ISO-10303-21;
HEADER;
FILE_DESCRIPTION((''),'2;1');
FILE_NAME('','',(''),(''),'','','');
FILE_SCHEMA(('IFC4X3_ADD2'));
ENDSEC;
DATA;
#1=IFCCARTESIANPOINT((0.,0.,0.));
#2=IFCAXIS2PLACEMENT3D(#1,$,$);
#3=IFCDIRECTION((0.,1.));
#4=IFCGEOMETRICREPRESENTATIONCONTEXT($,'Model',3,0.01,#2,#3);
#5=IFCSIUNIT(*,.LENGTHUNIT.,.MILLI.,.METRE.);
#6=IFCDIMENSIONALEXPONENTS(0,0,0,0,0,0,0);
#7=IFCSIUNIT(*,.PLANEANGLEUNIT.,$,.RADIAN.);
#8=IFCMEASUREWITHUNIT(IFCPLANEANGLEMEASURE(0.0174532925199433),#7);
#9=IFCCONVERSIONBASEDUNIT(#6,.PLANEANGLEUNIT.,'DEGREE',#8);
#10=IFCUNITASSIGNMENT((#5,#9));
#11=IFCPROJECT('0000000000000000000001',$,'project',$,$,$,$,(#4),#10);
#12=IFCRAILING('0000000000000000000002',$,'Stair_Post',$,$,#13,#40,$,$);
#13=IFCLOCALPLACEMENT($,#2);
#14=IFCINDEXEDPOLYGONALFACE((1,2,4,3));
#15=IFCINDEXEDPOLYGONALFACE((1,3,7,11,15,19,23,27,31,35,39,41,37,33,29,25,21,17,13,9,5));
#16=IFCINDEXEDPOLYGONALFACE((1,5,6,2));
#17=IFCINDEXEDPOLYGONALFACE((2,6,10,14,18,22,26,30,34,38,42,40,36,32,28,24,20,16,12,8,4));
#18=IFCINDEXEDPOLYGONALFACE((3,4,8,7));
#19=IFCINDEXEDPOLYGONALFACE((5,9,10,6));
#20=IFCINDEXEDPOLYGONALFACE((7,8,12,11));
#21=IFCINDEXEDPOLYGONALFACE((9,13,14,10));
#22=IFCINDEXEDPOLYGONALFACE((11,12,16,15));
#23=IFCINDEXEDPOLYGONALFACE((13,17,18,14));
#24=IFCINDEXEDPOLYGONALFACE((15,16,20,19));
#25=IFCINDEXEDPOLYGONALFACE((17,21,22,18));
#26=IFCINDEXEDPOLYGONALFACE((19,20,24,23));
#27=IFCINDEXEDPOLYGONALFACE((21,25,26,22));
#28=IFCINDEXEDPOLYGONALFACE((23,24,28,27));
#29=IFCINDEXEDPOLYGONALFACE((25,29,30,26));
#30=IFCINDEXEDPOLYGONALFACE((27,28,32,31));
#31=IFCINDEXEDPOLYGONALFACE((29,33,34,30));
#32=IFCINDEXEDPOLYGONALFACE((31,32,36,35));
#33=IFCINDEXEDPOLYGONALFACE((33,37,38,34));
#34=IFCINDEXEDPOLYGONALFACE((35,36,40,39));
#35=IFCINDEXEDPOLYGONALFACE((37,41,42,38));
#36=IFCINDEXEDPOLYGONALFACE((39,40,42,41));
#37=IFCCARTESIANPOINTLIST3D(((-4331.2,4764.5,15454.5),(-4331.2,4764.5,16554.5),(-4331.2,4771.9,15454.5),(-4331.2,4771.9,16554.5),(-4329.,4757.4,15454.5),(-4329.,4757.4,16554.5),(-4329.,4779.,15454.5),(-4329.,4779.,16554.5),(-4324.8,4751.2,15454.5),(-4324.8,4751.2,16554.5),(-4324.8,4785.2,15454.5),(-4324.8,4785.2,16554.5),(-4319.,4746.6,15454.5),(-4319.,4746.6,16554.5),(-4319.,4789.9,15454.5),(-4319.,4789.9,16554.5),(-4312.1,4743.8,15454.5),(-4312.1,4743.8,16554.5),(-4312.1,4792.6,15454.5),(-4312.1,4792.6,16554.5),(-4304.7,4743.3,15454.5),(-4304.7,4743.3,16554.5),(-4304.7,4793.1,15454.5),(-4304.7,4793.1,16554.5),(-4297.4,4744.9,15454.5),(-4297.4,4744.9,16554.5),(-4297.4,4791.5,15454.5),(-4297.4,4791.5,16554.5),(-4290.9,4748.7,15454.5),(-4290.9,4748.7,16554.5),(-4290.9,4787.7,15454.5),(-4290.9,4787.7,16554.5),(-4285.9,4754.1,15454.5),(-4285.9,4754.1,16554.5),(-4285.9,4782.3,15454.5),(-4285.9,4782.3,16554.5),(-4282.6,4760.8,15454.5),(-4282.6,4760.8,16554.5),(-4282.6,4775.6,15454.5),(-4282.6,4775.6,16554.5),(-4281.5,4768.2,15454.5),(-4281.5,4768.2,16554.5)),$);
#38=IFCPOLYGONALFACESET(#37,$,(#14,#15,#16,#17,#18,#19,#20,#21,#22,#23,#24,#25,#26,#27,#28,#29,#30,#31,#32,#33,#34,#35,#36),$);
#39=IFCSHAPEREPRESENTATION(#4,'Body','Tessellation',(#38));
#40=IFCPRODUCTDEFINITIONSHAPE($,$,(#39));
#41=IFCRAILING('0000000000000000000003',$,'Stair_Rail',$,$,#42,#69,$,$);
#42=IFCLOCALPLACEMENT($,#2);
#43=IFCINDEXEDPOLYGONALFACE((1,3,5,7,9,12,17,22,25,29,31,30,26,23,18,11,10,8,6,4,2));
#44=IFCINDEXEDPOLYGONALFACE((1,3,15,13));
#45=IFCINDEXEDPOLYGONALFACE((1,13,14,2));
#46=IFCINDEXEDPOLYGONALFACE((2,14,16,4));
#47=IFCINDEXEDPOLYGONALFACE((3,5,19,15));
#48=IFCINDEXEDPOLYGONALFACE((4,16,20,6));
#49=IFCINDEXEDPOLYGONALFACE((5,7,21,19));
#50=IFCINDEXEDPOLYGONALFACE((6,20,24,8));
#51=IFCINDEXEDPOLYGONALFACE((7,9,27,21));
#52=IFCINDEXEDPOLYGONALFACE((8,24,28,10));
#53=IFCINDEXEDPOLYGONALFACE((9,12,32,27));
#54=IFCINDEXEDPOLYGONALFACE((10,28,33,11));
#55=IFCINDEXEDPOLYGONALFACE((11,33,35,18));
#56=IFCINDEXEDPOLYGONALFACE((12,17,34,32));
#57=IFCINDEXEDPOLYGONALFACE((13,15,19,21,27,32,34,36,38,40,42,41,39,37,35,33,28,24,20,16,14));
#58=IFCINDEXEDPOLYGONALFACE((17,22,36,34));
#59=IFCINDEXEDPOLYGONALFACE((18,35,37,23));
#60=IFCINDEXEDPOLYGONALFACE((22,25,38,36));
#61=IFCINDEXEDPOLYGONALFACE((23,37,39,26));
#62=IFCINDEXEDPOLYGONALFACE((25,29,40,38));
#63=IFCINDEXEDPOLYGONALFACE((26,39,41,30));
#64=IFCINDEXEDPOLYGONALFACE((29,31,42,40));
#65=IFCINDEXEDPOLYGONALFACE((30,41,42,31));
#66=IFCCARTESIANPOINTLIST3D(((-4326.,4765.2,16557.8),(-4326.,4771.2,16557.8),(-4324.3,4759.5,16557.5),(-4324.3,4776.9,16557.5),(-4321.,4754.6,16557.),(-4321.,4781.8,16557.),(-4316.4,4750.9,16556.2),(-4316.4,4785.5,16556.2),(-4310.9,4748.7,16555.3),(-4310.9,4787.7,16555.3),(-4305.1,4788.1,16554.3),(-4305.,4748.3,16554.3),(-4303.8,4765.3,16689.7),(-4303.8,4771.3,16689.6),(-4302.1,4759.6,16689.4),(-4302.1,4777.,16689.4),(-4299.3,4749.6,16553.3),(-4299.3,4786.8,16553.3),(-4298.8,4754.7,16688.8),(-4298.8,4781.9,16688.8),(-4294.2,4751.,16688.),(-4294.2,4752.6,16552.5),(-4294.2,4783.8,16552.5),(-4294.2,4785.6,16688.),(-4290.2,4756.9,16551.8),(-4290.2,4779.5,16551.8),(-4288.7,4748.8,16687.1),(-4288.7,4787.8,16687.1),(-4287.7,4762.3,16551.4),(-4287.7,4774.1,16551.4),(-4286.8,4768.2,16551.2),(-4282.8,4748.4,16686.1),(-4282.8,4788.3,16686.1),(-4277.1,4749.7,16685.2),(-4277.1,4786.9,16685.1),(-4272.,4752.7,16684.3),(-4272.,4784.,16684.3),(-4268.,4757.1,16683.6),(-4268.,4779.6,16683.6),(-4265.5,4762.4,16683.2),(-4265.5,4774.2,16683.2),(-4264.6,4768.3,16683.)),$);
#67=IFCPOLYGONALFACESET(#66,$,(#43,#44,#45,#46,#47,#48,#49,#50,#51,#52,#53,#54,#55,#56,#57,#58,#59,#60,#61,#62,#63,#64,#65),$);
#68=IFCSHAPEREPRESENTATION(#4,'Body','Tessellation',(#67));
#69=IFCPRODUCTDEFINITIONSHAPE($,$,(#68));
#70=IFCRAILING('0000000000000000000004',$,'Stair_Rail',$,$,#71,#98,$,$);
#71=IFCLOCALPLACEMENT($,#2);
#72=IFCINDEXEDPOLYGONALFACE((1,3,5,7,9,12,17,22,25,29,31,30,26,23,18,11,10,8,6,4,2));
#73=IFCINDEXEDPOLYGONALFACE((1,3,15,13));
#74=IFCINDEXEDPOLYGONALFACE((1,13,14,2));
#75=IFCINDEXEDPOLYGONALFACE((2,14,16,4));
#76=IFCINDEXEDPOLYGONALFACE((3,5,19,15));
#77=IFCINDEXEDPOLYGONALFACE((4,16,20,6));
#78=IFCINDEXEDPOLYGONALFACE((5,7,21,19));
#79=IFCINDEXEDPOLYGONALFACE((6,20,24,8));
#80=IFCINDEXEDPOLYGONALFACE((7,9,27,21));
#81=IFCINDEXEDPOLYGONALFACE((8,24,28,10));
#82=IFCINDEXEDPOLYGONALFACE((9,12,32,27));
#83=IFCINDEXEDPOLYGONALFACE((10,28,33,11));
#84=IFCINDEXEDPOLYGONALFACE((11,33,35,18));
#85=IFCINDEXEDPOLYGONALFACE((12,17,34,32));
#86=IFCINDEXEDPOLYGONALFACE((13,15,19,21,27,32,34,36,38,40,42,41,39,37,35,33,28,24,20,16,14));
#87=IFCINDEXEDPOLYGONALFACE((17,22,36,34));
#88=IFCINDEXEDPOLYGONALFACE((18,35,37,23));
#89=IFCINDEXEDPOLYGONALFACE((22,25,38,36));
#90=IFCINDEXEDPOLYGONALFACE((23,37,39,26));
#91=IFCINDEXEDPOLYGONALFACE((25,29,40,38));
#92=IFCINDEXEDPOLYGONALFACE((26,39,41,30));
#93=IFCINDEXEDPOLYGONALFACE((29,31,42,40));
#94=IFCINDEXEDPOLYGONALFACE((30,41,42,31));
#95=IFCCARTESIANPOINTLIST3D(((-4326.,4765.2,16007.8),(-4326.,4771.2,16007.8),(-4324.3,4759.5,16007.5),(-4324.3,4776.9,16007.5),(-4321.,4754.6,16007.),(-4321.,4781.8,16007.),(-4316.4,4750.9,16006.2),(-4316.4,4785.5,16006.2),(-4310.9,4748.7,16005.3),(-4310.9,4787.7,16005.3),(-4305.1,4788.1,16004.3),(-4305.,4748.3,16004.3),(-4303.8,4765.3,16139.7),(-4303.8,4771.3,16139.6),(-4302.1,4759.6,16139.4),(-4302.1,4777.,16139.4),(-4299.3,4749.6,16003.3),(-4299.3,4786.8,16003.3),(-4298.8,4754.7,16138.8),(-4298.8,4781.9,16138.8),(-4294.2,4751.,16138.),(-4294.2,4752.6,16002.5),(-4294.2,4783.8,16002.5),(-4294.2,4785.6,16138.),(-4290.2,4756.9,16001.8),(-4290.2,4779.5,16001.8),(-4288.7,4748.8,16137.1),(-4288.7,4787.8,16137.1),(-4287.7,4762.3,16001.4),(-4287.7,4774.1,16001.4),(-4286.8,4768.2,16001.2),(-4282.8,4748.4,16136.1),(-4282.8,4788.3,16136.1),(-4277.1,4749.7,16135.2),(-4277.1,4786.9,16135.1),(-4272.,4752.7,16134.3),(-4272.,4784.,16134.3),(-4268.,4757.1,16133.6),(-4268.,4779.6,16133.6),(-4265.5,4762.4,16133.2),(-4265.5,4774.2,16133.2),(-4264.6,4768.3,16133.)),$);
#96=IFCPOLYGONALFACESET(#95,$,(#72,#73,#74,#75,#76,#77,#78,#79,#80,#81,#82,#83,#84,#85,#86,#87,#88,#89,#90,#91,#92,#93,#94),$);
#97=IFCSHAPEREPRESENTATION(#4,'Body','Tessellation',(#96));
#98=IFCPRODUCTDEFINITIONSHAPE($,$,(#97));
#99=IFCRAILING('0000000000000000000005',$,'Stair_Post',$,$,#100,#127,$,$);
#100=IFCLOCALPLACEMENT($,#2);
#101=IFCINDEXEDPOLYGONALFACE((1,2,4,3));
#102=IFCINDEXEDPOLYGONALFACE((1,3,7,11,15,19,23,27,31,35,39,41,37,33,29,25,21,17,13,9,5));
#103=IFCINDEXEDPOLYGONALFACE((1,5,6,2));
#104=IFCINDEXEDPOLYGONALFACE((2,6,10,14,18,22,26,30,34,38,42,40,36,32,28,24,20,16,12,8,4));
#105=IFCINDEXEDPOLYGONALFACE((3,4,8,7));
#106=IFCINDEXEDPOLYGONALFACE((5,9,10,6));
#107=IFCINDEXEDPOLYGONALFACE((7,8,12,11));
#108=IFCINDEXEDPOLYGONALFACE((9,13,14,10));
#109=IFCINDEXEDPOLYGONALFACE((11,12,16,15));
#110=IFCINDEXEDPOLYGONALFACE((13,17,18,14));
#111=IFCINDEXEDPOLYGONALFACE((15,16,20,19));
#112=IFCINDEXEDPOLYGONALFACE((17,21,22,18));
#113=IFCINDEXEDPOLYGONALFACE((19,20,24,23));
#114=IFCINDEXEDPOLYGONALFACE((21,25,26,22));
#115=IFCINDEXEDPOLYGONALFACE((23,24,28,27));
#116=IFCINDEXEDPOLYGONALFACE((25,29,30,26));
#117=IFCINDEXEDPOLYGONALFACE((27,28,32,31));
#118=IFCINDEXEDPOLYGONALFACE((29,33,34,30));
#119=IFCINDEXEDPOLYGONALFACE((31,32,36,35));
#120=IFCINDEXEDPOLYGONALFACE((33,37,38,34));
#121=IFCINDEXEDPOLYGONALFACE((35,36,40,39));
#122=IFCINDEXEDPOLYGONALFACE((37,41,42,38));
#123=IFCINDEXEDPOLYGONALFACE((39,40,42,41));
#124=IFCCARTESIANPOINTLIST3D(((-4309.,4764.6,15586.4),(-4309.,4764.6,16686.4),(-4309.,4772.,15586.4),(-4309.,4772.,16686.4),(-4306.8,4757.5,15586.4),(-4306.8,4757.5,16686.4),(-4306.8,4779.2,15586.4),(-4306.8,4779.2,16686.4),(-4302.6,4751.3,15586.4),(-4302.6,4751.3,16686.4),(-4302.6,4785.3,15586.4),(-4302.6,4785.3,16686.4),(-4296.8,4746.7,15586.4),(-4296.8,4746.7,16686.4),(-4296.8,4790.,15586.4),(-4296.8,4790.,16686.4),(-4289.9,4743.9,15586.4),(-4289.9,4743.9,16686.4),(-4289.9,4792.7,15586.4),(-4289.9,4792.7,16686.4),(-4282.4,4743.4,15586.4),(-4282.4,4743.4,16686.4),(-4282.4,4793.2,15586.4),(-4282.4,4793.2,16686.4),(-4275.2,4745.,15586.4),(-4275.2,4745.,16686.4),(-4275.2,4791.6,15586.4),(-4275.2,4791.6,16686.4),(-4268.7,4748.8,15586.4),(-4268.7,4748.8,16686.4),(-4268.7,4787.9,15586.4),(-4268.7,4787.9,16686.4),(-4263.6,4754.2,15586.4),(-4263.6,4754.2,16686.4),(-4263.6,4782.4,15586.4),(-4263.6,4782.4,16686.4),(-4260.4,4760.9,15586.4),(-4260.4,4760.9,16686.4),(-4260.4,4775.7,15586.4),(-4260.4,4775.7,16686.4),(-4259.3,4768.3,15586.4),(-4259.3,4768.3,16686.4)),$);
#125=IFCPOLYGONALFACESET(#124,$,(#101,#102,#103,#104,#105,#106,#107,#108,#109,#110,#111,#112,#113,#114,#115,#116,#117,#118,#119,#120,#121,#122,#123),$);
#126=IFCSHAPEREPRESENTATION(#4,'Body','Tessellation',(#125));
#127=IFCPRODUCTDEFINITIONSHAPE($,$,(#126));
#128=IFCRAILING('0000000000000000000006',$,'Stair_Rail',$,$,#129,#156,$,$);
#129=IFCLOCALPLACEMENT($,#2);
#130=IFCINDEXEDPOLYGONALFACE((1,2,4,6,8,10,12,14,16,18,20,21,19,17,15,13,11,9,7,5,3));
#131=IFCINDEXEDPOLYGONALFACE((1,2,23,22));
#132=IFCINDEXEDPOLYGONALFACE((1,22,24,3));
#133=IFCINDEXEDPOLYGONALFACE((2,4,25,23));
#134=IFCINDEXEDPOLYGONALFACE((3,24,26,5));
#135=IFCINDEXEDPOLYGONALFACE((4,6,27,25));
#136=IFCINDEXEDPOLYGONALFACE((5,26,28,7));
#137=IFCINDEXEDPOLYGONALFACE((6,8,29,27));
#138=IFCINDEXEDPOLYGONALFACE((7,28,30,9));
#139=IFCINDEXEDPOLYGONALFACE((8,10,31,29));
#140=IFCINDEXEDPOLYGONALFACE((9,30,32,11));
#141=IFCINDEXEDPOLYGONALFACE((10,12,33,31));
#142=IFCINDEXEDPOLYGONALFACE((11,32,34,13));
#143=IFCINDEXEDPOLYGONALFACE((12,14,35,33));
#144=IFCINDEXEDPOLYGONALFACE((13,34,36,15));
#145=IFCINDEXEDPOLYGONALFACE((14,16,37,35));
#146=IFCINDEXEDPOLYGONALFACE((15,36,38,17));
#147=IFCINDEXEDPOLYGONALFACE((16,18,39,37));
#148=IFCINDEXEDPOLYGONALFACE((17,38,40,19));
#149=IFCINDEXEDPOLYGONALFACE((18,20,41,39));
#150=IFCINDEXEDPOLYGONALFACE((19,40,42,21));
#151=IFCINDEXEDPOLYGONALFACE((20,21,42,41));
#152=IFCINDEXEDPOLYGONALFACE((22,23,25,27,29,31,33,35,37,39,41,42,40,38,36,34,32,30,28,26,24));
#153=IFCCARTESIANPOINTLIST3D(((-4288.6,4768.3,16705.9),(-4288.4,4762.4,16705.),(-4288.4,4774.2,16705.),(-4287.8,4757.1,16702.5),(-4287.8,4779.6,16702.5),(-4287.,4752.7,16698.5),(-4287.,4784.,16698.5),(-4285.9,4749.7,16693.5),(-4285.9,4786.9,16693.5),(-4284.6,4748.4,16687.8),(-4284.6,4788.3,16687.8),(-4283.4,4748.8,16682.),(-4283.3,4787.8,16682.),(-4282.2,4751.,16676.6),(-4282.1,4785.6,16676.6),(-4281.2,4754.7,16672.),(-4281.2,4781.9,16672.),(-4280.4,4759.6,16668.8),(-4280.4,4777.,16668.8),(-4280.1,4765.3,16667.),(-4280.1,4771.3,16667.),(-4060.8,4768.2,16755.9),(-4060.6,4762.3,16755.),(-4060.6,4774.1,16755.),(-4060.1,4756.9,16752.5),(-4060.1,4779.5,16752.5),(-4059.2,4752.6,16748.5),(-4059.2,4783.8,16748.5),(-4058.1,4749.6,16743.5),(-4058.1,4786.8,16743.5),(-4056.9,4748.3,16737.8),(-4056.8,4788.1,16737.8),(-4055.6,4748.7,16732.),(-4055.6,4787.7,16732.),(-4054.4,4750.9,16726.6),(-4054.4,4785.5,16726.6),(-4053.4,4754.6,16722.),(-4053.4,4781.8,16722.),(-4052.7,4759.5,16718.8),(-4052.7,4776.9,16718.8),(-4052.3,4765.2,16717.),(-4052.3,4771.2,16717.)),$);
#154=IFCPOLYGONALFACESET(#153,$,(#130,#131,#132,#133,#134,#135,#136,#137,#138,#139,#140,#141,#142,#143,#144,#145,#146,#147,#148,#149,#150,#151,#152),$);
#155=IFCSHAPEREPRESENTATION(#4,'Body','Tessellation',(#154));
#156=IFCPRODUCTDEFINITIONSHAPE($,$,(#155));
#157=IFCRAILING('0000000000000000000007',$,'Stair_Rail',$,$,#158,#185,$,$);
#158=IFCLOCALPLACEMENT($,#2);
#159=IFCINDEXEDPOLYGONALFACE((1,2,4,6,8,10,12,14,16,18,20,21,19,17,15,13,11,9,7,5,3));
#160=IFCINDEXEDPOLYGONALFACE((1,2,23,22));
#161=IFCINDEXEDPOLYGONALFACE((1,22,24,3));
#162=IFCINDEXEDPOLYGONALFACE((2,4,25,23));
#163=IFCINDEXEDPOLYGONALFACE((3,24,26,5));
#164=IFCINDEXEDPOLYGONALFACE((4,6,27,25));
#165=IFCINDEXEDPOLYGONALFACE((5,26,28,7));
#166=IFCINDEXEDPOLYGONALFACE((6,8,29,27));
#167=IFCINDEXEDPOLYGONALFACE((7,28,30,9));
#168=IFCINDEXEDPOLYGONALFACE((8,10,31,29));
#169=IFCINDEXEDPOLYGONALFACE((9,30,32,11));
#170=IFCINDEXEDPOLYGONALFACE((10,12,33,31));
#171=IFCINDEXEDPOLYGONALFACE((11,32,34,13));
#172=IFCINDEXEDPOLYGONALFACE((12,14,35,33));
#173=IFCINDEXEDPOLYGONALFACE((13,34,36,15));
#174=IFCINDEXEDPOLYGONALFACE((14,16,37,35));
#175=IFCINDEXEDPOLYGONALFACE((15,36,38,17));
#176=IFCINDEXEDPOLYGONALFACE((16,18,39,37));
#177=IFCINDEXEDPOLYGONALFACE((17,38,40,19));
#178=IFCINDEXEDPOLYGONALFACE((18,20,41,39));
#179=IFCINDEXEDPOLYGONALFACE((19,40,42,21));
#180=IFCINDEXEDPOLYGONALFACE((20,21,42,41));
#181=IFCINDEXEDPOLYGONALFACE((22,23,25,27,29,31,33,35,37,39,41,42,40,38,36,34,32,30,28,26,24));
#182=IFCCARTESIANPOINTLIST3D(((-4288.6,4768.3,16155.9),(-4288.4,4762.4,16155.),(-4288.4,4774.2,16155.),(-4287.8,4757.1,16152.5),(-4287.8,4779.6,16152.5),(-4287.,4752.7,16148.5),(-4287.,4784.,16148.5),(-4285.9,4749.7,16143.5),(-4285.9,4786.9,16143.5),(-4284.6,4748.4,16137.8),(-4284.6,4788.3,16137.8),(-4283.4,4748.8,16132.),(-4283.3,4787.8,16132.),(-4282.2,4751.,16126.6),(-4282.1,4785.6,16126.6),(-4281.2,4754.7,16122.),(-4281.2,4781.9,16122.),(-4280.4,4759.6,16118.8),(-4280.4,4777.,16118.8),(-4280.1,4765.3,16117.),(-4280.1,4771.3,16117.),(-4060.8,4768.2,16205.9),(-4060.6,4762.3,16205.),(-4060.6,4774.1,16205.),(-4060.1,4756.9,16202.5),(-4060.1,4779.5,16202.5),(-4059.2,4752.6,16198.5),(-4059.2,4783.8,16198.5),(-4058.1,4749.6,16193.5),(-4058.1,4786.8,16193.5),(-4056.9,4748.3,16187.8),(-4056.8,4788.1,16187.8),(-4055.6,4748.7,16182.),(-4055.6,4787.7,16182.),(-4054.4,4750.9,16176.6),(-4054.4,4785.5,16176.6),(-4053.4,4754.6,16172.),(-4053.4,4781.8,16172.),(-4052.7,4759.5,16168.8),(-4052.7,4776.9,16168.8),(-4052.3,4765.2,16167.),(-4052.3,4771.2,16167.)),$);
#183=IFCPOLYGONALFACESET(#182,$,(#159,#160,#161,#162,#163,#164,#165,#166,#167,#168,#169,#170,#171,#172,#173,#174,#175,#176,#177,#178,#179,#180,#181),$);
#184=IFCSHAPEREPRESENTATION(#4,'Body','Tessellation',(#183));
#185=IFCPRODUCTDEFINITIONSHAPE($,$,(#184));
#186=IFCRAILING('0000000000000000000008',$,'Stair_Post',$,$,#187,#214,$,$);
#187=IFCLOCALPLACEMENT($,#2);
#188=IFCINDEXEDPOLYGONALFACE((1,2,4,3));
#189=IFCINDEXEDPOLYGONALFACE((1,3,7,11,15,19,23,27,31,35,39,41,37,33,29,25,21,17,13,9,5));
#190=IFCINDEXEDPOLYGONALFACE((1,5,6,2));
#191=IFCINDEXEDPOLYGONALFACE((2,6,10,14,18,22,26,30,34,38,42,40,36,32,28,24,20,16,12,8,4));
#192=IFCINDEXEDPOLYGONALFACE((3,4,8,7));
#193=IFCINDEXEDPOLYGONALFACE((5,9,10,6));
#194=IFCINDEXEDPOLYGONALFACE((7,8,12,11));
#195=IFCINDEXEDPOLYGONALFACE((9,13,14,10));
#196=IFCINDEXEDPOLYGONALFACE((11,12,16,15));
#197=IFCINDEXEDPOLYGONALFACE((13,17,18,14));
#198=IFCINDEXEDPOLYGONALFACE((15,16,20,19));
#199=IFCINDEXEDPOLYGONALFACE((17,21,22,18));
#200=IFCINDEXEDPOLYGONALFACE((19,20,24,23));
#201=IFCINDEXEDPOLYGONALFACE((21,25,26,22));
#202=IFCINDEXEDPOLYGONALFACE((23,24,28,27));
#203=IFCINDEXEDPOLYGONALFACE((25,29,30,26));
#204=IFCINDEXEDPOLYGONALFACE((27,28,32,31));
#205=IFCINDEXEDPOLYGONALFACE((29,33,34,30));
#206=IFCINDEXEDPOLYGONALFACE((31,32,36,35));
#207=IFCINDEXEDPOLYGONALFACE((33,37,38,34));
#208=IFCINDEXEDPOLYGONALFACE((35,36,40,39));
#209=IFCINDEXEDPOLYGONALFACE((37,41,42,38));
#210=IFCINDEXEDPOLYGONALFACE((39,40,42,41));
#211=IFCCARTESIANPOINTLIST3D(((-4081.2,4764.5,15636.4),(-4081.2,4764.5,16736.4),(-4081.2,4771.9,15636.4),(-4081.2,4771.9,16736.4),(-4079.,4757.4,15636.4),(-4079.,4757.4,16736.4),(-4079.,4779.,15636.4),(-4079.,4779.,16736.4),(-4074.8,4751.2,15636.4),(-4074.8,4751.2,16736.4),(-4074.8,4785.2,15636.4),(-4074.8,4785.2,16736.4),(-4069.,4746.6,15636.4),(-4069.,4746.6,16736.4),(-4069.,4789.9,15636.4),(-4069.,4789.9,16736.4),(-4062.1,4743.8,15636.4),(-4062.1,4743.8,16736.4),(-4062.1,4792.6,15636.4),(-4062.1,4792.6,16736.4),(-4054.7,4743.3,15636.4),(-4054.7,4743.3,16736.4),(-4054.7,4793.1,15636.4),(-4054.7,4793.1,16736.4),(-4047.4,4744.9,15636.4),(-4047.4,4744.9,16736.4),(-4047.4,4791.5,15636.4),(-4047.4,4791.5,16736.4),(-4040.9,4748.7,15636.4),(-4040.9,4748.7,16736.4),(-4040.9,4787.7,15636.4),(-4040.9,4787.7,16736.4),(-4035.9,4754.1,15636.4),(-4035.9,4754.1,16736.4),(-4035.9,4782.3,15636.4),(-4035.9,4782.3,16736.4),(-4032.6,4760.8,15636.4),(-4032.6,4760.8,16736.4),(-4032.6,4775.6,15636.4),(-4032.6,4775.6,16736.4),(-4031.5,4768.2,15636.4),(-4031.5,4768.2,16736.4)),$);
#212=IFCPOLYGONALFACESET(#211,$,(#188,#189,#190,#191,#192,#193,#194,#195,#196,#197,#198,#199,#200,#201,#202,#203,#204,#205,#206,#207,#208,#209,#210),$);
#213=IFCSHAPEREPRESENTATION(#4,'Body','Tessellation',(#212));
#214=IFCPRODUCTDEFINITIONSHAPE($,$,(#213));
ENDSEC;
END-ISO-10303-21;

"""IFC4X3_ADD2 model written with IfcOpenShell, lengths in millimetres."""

from ifc_helpers import new_model, entity, si_unit, converted_unit, direction, frame, origin, context, project, circle, extrude, element, save


model = new_model("IFC4X3_ADD2")

# Units and contexts
model_context = context("Model", 3, precision=0.01, world=origin(), true_north=direction((0.0, 1.0)))
ifc_project = project(units=[si_unit("LENGTHUNIT", "METRE", prefix="MILLI"), converted_unit("PLANEANGLEUNIT", "DEGREE", entity("IfcPlaneAngleMeasure", 0.0174532925199433), si_unit("PLANEANGLEUNIT", "RADIAN"), dimensions=[0, 0, 0, 0, 0, 0, 0])], contexts=[model_context])

# Railings
element("IfcRailing", 1, Name="Stair_Post", context=model_context, shape_type="SweptSolid", body=[
    extrude(circle(Radius=25.0), frame((-4306.5, 4768.2, 15454.5)), (0.0, 0.0, 1.0), 1100.0),
])
element("IfcRailing", 2, Name="Stair_Rail", context=model_context, shape_type="SweptSolid", body=[
    entity("IfcSweptDiskSolid", entity("IfcPolyline", [entity("IfcCartesianPoint", [-4306.5, 4768.2, 16554.5]), entity("IfcCartesianPoint", [-4284.3, 4768.3, 16686.4])]), 20.0),
])
element("IfcRailing", 3, Name="Stair_Rail", context=model_context, shape_type="SweptSolid", body=[
    entity("IfcSweptDiskSolid", entity("IfcPolyline", [entity("IfcCartesianPoint", [-4306.5, 4768.2, 16004.5]), entity("IfcCartesianPoint", [-4284.3, 4768.3, 16136.4])]), 20.0),
])
element("IfcRailing", 4, Name="Stair_Post", context=model_context, shape_type="SweptSolid", body=[
    extrude(circle(Radius=25.0), frame((-4284.3, 4768.3, 15586.4)), (0.0, 0.0, 1.0), 1100.0),
])
element("IfcRailing", 5, Name="Stair_Rail", context=model_context, shape_type="SweptSolid", body=[
    entity("IfcSweptDiskSolid", entity("IfcPolyline", [entity("IfcCartesianPoint", [-4284.3, 4768.3, 16686.4]), entity("IfcCartesianPoint", [-4056.5, 4768.2, 16736.4])]), 20.0),
])
element("IfcRailing", 6, Name="Stair_Rail", context=model_context, shape_type="SweptSolid", body=[
    entity("IfcSweptDiskSolid", entity("IfcPolyline", [entity("IfcCartesianPoint", [-4284.3, 4768.3, 16136.4]), entity("IfcCartesianPoint", [-4056.5, 4768.2, 16186.4])]), 20.0),
])
element("IfcRailing", 7, Name="Stair_Post", context=model_context, shape_type="SweptSolid", body=[
    extrude(circle(Radius=25.0), frame((-4056.5, 4768.2, 15636.4)), (0.0, 0.0, 1.0), 1100.0),
])

save(model, "model.ifc")
